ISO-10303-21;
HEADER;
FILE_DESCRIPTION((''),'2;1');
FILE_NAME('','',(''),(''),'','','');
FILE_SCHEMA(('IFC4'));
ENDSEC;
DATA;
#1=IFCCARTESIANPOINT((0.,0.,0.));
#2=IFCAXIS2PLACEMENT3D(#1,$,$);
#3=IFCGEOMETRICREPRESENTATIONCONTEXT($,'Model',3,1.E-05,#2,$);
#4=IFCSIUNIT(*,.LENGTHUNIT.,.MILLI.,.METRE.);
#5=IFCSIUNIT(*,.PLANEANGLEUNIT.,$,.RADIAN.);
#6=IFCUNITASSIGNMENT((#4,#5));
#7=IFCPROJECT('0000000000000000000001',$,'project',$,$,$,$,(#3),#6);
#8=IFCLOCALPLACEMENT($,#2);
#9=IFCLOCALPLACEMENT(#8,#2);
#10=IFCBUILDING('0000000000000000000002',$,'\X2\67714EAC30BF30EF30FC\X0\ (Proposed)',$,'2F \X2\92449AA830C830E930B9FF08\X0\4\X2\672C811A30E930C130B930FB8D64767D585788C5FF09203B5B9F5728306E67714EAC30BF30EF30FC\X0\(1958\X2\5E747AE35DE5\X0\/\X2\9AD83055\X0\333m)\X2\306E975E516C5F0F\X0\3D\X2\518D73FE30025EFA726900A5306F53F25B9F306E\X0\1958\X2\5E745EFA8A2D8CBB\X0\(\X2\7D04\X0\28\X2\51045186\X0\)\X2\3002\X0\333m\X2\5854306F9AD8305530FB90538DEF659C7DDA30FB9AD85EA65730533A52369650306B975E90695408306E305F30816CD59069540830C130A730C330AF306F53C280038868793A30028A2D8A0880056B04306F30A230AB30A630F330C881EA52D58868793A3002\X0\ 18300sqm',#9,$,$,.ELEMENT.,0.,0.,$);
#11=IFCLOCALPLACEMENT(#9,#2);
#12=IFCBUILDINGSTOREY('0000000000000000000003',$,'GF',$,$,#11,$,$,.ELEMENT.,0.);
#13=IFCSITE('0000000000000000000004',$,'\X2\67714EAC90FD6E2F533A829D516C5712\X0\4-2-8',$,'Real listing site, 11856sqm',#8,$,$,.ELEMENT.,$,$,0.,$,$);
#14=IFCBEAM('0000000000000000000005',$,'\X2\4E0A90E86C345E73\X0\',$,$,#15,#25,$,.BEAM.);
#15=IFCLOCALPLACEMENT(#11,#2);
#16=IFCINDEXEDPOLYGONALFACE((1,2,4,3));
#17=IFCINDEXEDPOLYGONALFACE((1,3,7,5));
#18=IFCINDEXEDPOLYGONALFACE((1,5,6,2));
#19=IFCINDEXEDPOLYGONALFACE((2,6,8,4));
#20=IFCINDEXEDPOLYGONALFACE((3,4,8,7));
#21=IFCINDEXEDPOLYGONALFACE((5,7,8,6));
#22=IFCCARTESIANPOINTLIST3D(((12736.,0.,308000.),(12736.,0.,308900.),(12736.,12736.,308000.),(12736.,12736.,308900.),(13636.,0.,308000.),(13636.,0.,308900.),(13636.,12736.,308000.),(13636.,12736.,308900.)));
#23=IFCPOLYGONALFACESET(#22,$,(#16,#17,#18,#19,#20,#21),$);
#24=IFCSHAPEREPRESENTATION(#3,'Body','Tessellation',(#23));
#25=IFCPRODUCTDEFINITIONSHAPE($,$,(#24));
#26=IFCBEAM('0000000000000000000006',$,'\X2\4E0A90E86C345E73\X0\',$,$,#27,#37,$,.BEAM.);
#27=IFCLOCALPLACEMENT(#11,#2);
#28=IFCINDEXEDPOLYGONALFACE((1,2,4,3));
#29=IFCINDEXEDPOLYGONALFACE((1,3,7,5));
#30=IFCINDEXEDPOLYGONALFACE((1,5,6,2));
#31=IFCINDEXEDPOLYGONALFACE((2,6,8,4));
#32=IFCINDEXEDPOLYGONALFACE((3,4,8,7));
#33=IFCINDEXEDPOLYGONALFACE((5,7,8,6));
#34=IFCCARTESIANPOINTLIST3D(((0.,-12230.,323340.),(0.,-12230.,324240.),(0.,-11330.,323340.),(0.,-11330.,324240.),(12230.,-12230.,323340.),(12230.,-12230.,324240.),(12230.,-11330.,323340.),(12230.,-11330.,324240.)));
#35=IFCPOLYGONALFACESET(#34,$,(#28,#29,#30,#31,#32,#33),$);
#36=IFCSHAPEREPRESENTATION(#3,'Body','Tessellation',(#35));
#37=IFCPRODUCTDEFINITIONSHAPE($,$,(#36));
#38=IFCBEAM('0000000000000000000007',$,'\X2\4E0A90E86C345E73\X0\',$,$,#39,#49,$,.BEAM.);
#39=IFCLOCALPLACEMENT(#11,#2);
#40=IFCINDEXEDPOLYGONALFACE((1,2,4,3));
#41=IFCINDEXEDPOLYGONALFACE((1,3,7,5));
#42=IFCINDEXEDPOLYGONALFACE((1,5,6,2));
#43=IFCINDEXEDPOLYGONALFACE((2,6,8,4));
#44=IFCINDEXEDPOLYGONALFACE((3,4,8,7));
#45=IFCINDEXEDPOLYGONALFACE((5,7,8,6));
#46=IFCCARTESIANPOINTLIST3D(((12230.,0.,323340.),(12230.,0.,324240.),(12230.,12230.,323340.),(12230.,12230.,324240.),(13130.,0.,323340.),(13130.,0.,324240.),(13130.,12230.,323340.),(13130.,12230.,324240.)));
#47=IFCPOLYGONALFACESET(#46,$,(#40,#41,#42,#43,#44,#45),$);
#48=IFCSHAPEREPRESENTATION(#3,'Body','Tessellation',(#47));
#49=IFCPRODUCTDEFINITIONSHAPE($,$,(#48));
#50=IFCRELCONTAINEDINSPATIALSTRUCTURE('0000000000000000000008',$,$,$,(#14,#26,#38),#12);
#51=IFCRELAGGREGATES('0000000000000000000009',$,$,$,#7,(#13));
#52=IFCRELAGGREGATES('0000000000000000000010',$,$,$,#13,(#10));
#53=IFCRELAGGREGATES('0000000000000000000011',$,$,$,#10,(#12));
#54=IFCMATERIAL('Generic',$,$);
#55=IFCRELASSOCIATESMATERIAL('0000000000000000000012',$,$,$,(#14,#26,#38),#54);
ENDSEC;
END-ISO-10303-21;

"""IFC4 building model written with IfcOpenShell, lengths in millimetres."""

from ifc_helpers import new_model, si_unit, frame, frame_2d, origin, place, context, project, spatial, rectangle, extrude, material, element, save


model = new_model("IFC4")

# Units and contexts
model_context = context("Model", 3, precision=1e-05, world=origin())
ifc_project = project(units=[si_unit("LENGTHUNIT", "METRE", prefix="MILLI"), si_unit("PLANEANGLEUNIT", "RADIAN")], contexts=[model_context])

# Site, building, storey
site_placement = place(None, origin())
site = spatial("IfcSite", under=ifc_project, at=site_placement, Name="東京都港区芝公園4-2-8", ObjectType="Real listing site, 11856sqm", CompositionType="ELEMENT", RefElevation=0.0)
building_placement = place(site_placement, origin())
building = spatial("IfcBuilding", under=site, at=building_placement, Name="東京タワー (Proposed)", ObjectType="2F 鉄骨トラス（4本脚ラチス・赤白塗装）※実在の東京タワー(1958年竣工/高さ333m)の非公式3D再現。建物¥は史実の1958年建設費(約28億円)。333m塔は高さ・道路斜線・高度地区制限に非適合のため法適合チェックは参考表示。設計者欄はアカウント自動表示。 18300sqm", CompositionType="ELEMENT", ElevationOfRefHeight=0.0, ElevationOfTerrain=0.0)
storey_placement = place(building_placement, origin())
storey = spatial("IfcBuildingStorey", under=building, at=storey_placement, Name="GF", CompositionType="ELEMENT", Elevation=0.0)

# Shared definitions
ifc_material = material(Name="Generic")

# Beams
beam_1_placement = place(storey_placement, frame((6368.0, 0.0, 154000.0)))
element("IfcBeam", 1, at=beam_1_placement, inside=storey, material=ifc_material, Name="上部水平", PredefinedType="BEAM", context=model_context, shape_type="SweptSolid", body=[
    extrude(rectangle(XDim=900.0, YDim=12736.0, at=frame_2d((450.0, 6368.0))), frame((6368.0, 0.0, 154000.0)), (0.0, 0.0, 1.0), 900.0),
])
beam_2_placement = place(storey_placement, frame((0.0, -6115.0, 161670.0)))
element("IfcBeam", 2, at=beam_2_placement, inside=storey, material=ifc_material, Name="上部水平", PredefinedType="BEAM", context=model_context, shape_type="SweptSolid", body=[
    extrude(rectangle(XDim=12230.0, YDim=900.0, at=frame_2d((6115.0, 450.0))), frame((0.0, -6115.0, 161670.0)), (0.0, 0.0, 1.0), 900.0),
])
beam_3_placement = place(storey_placement, frame((6115.0, 0.0, 161670.0)))
element("IfcBeam", 3, at=beam_3_placement, inside=storey, material=ifc_material, Name="上部水平", PredefinedType="BEAM", context=model_context, shape_type="SweptSolid", body=[
    extrude(rectangle(XDim=900.0, YDim=12230.0, at=frame_2d((450.0, 6115.0))), frame((6115.0, 0.0, 161670.0)), (0.0, 0.0, 1.0), 900.0),
])

save(model, "model.ifc")
